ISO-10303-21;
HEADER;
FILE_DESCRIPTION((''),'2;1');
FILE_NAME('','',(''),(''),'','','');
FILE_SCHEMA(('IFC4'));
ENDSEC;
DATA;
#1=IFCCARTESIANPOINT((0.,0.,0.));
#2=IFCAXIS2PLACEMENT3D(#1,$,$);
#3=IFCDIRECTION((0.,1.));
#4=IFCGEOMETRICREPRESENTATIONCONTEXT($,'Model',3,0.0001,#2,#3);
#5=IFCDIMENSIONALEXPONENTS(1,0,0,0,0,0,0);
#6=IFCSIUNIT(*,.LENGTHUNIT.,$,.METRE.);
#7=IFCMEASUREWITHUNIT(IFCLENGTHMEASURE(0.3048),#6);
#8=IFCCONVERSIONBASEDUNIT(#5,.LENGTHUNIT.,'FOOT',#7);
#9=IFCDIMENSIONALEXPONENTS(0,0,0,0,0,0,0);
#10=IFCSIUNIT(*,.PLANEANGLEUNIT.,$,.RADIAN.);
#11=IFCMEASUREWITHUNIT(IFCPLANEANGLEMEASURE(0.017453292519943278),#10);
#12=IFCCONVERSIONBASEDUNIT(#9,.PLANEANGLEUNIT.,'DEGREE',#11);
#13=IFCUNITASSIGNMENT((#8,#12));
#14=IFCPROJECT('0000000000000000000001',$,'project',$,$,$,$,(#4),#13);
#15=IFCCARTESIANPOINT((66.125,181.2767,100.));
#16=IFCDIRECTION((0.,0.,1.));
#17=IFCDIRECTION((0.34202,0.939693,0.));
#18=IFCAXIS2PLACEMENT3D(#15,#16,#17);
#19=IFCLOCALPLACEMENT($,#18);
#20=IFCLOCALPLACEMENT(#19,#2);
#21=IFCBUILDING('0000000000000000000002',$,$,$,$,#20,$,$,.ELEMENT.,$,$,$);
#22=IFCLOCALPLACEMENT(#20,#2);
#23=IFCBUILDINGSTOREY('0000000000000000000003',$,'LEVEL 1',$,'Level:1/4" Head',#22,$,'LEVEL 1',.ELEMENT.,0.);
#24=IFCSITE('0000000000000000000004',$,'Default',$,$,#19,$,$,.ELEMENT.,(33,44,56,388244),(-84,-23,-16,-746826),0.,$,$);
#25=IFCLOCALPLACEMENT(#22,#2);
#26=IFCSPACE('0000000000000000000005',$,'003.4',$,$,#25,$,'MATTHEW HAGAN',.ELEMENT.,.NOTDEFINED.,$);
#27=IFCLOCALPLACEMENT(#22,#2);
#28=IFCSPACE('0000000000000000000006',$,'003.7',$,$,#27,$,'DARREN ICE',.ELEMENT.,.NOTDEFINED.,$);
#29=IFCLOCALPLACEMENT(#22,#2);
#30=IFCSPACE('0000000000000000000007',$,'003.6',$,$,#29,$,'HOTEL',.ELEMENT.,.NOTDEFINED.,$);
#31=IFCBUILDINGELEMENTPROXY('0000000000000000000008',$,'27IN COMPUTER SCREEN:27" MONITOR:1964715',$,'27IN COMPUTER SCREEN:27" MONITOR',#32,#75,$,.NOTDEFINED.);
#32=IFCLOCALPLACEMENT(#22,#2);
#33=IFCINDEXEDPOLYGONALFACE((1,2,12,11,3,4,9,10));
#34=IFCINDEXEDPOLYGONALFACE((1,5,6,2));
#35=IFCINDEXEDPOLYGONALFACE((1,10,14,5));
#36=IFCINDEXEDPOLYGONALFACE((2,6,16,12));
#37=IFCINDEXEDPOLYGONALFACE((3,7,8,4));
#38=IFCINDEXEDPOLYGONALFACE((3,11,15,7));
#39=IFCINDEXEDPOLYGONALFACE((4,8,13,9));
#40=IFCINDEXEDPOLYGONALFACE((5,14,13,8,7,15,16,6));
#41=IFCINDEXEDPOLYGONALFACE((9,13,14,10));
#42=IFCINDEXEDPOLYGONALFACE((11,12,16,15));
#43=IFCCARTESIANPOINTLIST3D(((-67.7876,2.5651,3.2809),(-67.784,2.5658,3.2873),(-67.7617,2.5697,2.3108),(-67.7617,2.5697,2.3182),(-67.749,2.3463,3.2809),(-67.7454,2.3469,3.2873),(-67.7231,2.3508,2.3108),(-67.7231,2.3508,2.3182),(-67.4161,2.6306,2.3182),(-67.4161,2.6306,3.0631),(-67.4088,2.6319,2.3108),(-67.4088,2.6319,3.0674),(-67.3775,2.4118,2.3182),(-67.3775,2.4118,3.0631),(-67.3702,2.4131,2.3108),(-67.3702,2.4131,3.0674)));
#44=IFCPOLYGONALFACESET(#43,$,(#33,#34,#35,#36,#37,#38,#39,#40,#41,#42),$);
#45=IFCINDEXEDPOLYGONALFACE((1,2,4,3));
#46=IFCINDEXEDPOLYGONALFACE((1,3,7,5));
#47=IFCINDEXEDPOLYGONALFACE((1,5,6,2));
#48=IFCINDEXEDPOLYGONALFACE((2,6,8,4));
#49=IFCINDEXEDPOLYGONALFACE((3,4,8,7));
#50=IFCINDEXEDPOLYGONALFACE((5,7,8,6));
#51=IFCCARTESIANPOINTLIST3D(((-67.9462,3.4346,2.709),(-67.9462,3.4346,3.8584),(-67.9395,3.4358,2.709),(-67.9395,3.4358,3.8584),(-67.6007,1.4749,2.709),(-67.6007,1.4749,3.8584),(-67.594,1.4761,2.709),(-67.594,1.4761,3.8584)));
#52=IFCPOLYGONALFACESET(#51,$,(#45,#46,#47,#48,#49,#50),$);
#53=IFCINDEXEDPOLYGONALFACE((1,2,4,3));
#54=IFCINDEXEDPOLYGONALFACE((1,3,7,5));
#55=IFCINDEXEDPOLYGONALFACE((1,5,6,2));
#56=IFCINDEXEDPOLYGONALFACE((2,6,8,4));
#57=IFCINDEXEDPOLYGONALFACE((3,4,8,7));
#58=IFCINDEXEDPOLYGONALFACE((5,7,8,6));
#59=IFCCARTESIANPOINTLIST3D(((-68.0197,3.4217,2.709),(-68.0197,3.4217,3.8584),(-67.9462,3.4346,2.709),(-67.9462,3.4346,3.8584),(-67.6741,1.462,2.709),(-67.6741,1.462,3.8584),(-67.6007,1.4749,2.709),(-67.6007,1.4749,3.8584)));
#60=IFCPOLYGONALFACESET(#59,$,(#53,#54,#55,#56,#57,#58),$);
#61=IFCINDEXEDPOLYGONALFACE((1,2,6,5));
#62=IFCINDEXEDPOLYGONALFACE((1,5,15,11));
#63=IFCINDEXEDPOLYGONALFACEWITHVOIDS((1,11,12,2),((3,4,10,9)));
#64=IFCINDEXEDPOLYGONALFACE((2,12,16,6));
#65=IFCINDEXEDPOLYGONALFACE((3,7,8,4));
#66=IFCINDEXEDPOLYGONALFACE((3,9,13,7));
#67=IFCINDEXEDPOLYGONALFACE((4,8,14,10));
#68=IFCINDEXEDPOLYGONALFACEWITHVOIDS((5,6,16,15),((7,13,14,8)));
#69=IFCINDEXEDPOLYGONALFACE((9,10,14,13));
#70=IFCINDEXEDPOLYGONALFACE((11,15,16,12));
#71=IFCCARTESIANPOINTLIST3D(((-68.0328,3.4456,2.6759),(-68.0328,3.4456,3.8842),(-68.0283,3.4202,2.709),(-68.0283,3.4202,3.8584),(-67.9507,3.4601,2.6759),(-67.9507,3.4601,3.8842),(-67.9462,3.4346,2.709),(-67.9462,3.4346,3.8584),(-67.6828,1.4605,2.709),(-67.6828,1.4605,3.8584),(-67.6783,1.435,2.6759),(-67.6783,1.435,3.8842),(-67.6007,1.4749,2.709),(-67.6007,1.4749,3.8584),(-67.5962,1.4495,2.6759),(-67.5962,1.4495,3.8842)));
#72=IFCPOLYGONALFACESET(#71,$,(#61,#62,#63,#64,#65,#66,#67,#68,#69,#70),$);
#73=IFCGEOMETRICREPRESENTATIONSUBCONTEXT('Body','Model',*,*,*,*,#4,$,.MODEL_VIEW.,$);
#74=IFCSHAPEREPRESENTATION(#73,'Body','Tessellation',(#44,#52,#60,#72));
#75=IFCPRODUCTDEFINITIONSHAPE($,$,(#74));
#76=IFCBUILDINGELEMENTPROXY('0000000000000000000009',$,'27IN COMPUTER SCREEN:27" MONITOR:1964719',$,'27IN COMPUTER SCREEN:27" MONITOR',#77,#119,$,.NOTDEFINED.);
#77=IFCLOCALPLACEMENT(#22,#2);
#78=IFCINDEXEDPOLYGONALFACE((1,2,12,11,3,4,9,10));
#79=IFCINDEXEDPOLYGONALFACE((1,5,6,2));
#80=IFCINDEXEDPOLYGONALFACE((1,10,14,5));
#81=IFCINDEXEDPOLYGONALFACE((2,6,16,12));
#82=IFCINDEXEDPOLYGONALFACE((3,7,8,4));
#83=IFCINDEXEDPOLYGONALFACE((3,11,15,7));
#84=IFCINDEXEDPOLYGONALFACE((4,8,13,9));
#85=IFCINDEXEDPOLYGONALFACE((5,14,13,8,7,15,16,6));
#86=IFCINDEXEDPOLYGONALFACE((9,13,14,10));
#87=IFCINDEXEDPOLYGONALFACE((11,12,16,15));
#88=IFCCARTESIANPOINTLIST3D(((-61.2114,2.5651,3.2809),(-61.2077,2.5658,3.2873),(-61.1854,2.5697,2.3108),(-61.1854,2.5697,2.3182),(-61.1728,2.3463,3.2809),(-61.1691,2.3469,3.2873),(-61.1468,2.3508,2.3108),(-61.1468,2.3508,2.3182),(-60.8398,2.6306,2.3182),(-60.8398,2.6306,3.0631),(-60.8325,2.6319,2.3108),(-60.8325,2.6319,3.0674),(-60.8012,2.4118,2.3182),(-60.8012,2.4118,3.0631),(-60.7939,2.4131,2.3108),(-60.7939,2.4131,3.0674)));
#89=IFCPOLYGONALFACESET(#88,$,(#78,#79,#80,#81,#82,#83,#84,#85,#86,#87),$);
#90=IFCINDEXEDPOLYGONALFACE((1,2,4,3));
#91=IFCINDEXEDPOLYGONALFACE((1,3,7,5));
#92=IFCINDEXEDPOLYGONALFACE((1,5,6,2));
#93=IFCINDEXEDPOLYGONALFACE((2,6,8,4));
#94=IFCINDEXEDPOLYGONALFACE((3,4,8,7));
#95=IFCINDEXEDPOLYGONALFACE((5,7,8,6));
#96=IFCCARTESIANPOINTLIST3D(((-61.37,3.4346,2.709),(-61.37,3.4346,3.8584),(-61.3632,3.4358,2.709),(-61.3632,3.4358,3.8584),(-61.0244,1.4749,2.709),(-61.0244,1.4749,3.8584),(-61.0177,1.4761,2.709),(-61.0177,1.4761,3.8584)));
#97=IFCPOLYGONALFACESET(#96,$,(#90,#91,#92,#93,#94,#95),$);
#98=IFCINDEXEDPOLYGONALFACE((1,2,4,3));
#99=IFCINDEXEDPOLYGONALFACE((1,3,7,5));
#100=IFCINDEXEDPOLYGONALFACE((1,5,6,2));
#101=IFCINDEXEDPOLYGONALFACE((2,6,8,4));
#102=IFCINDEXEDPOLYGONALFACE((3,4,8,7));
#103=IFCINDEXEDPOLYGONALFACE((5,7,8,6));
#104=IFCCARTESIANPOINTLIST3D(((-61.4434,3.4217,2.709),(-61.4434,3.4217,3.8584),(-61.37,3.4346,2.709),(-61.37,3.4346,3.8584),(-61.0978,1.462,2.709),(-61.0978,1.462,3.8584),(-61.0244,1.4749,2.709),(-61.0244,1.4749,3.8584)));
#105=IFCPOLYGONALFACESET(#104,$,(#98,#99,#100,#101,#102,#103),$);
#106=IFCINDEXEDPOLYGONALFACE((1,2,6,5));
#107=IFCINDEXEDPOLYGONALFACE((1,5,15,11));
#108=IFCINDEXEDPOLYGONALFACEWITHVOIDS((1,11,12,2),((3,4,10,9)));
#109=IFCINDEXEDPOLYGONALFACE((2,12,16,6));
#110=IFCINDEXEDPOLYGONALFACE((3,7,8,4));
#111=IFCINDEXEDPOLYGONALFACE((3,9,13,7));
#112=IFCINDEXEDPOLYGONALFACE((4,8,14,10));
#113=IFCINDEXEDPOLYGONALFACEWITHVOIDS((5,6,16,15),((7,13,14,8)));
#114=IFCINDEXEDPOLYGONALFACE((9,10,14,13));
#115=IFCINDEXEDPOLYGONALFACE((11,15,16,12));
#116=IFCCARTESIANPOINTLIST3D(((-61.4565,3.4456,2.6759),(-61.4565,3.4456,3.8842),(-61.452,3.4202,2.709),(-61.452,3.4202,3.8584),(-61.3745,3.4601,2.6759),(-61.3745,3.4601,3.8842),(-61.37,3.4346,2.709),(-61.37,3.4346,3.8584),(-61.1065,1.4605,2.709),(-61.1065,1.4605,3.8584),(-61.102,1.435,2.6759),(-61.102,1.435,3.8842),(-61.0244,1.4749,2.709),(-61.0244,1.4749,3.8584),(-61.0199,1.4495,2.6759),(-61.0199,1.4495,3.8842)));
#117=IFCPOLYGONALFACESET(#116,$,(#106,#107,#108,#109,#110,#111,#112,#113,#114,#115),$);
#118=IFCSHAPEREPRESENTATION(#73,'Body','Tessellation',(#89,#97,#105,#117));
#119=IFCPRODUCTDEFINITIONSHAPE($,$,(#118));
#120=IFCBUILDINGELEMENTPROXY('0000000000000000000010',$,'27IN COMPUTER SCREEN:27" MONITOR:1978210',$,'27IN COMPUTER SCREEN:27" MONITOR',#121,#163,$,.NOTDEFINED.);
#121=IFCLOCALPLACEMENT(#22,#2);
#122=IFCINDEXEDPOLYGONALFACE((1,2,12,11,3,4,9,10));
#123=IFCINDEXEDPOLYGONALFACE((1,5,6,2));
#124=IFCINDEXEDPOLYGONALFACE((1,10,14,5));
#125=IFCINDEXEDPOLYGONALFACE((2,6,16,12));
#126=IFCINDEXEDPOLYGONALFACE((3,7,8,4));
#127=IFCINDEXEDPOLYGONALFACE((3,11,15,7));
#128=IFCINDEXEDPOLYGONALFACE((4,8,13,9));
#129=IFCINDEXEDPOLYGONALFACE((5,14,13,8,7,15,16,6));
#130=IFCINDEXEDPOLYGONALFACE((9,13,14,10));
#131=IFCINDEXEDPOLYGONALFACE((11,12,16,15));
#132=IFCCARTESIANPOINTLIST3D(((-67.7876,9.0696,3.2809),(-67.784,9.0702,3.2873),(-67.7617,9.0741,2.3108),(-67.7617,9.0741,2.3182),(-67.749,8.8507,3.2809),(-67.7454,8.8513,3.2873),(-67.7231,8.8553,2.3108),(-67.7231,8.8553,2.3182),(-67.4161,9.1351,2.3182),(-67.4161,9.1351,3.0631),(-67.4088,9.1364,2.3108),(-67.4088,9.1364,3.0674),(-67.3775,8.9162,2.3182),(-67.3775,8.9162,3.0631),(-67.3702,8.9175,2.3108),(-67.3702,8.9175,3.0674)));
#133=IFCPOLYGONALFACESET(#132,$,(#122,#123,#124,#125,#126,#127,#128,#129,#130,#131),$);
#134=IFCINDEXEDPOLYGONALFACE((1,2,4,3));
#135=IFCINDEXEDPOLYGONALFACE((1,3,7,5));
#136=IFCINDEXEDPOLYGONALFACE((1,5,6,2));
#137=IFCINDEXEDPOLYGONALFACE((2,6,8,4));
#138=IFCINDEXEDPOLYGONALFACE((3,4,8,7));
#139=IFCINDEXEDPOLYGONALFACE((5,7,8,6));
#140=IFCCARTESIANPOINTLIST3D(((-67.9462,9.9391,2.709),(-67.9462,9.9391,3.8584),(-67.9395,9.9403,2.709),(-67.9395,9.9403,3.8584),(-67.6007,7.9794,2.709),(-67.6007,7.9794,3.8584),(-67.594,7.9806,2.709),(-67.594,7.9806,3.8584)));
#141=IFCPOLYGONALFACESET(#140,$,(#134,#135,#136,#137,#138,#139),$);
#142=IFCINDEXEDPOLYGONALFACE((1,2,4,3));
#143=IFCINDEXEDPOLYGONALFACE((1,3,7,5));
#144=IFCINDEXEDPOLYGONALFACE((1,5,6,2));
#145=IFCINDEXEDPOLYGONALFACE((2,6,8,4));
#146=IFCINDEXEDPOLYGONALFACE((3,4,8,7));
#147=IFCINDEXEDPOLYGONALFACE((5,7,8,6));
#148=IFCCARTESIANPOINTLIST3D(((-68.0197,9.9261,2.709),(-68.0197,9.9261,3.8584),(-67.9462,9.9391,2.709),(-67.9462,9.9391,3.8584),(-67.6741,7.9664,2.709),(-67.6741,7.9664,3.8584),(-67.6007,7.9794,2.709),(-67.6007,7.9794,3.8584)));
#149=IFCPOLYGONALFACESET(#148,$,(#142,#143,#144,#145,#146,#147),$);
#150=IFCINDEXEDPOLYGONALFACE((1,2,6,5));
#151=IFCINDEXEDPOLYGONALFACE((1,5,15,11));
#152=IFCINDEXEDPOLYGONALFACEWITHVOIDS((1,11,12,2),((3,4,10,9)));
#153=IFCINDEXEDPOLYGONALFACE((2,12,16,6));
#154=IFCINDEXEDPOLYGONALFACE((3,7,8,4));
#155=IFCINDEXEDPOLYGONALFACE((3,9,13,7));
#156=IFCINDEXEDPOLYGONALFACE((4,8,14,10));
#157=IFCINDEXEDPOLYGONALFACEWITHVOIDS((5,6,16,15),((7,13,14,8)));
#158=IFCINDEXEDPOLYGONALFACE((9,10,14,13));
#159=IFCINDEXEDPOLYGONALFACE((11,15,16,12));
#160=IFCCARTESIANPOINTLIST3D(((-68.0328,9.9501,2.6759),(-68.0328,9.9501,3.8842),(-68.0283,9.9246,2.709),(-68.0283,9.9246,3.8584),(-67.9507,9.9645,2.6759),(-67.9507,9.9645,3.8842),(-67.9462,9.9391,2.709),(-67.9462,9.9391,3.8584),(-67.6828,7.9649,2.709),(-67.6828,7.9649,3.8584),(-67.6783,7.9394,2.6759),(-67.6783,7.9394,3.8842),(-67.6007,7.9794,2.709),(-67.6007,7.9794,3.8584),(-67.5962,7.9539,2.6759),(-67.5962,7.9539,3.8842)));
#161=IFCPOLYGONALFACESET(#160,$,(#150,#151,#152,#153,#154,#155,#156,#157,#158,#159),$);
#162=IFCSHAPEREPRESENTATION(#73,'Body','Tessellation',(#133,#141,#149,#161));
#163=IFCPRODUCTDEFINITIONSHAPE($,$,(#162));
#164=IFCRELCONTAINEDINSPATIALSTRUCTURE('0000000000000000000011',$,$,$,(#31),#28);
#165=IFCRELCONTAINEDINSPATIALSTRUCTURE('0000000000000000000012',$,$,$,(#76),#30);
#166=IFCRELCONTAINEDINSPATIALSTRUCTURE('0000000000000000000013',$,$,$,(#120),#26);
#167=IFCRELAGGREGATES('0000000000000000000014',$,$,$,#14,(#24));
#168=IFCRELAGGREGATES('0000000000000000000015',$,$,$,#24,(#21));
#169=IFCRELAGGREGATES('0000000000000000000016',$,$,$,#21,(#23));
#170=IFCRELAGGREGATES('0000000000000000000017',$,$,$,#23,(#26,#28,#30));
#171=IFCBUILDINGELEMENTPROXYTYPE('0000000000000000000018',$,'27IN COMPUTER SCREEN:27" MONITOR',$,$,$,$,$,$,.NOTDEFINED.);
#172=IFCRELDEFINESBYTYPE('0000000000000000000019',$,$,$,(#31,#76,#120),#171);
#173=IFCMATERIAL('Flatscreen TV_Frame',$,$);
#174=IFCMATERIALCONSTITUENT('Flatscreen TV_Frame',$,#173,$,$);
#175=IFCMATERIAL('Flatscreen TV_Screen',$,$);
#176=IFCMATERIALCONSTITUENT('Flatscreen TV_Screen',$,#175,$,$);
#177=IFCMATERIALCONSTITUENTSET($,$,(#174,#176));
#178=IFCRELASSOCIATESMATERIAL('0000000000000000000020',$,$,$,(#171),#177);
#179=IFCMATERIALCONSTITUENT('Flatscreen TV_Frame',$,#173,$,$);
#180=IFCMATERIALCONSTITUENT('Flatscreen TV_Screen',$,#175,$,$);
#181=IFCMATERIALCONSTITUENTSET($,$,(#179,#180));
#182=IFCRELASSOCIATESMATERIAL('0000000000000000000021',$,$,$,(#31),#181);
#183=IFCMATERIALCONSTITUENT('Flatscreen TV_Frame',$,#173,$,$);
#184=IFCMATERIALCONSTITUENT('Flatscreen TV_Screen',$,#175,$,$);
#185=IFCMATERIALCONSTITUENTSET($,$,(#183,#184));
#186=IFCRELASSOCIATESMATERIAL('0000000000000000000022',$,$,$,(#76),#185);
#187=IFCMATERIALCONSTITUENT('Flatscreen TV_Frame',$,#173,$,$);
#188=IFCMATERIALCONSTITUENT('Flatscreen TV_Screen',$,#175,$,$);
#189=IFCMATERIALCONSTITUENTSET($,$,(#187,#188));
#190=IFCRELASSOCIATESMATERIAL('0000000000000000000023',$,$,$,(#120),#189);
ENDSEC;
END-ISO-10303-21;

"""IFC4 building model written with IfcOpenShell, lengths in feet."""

from ifc_helpers import new_model, entity, si_unit, converted_unit, direction, frame, frame_2d, origin, origin_2d_with_axis, place, context, subcontext, project, spatial, polyline, rectangle, outline, extrude, source, transform, mapped, material, constituent, constituent_set, type_object, type_shapes, element, save


model = new_model("IFC4")

# Units and contexts
model_context = context("Model", 3, precision=0.0001, world=origin(), true_north=direction((0.0, 1.0)))
body_context = subcontext(model_context, "Body", "Model", "MODEL_VIEW")
ifc_project = project(units=[converted_unit("LENGTHUNIT", "FOOT", entity("IfcLengthMeasure", 0.3048), si_unit("LENGTHUNIT", "METRE"), dimensions=[1, 0, 0, 0, 0, 0, 0]), converted_unit("PLANEANGLEUNIT", "DEGREE", entity("IfcPlaneAngleMeasure", 0.017453292519943278), si_unit("PLANEANGLEUNIT", "RADIAN"), dimensions=[0, 0, 0, 0, 0, 0, 0])], contexts=[model_context])

# Site, building, storey
site_placement = place(None, frame((66.125, 181.2767, 100.0), z_axis=(0.0, 0.0, 1.0), x_axis=(0.34202, 0.939693, 0.0)))
site = spatial("IfcSite", under=ifc_project, at=site_placement, Name="Default", CompositionType="ELEMENT", RefLatitude=(33, 44, 56, 388244), RefLongitude=(-84, -23, -16, -746826), RefElevation=0.0)
building_placement = place(site_placement, origin())
building = spatial("IfcBuilding", under=site, at=building_placement, CompositionType="ELEMENT")
storey_placement = place(building_placement, origin())
storey = spatial("IfcBuildingStorey", under=building, at=storey_placement, Name="LEVEL 1", ObjectType="Level:1/4\" Head", LongName="LEVEL 1", CompositionType="ELEMENT", Elevation=0.0)

# Shared definitions
space_1_placement = place(storey_placement, origin())
space_1 = spatial("IfcSpace", under=storey, at=space_1_placement, Name="003.4", LongName="MATTHEW HAGAN", CompositionType="ELEMENT", PredefinedType="NOTDEFINED")

# Shared definitions
space_2_placement = place(storey_placement, origin())
space_2 = spatial("IfcSpace", under=storey, at=space_2_placement, Name="003.7", LongName="DARREN ICE", CompositionType="ELEMENT", PredefinedType="NOTDEFINED")

# Shared definitions
space_3_placement = place(storey_placement, origin())
space_3 = spatial("IfcSpace", under=storey, at=space_3_placement, Name="003.6", LongName="HOTEL", CompositionType="ELEMENT", PredefinedType="NOTDEFINED")

# Shared definitions
ifc_material_1 = material(Name="Flatscreen TV_Frame")
ifc_material_2 = material(Name="Flatscreen TV_Screen")

# Building element proxies
ifc_constituent_1 = constituent(ifc_material_1, Name="Flatscreen TV_Frame")
ifc_constituent_2 = constituent(ifc_material_2, Name="Flatscreen TV_Screen")
ifc_constituent_set_1 = constituent_set(constituents=[ifc_constituent_1, ifc_constituent_2])
ifc_constituent_3 = constituent(ifc_material_1, Name="Flatscreen TV_Frame")
ifc_constituent_4 = constituent(ifc_material_2, Name="Flatscreen TV_Screen")
ifc_constituent_set_2 = constituent_set(constituents=[ifc_constituent_3, ifc_constituent_4])
building_element_proxy_type_1 = type_object("IfcBuildingElementProxyType", Name="27IN COMPUTER SCREEN:27\" MONITOR", PredefinedType="NOTDEFINED", material=ifc_constituent_set_2)
shared_shape_1 = source(origin(), body_context, "Body", "SweptSolid", [
    extrude(outline(polyline([(0.3657, -0.4392), (0.3731, -0.4392), (0.3731, 0.0007), (-0.2821, 0.379), (-0.4613, 0.0686), (-0.4548, 0.0649), (-0.2794, 0.3688), (0.3657, -0.0036), (0.3657, -0.4392)])), frame((-0.1111, 0.0264, 0.0687), z_axis=(1.0, 0.0, 0.0), x_axis=(0.0, -0.5, 0.866025)), (0.0, 0.0, 1.0), 0.2222),
    extrude(rectangle(XDim=1.9899, YDim=0.0068, at=origin_2d_with_axis()), frame((0.0, 0.2257, 0.0331), z_axis=(0.0, 0.0, 1.0), x_axis=(-1.0, 0.0, 0.0)), (0.0, 0.0, 1.0), 1.1493),
    extrude(rectangle(XDim=1.9899, YDim=0.0746, at=frame_2d((0.0, 0.0), x_axis=(1.0, 0.0))), frame((0.0, 0.2664, 0.0331), z_axis=(0.0, 0.0, 1.0), x_axis=(-1.0, 0.0, 0.0)), (0.0, 0.0, 1.0), 1.1493),
    extrude(outline(polyline([(-0.6042, -1.0208), (0.6042, -1.0208), (0.6042, 1.0208), (-0.6042, 1.0208), (-0.6042, -1.0208)]), holes=[polyline([(-0.5783, -0.995), (-0.5783, 0.995), (0.571, 0.995), (0.571, -0.995), (-0.5783, -0.995)])]), frame((0.0, 0.2292, 0.6042), z_axis=(0.0, 1.0, 0.0), x_axis=(0.0, 0.0, -1.0)), (0.0, 0.0, 1.0), 0.0833),
])
type_shapes(building_element_proxy_type_1, [shared_shape_1])
proxy_1_placement = place(space_2_placement, frame((-67.5478, 2.4946, 2.6759), z_axis=(0.0, 0.0, 1.0), x_axis=(-0.173648, 0.984808, 0.0)))
element("IfcBuildingElementProxy", 1, at=proxy_1_placement, inside=space_2, type_object=building_element_proxy_type_1, material=ifc_constituent_set_1, Name="27IN COMPUTER SCREEN:27\" MONITOR:1964715", ObjectType="27IN COMPUTER SCREEN:27\" MONITOR", PredefinedType="NOTDEFINED", context=body_context, shape_type="MappedRepresentation", body=[
    mapped(shared_shape_1, transform((0.0, 0.0, 0.0), scale=1.0)),
])
ifc_constituent_5 = constituent(ifc_material_1, Name="Flatscreen TV_Frame")
ifc_constituent_6 = constituent(ifc_material_2, Name="Flatscreen TV_Screen")
ifc_constituent_set_3 = constituent_set(constituents=[ifc_constituent_5, ifc_constituent_6])
proxy_2_placement = place(space_3_placement, frame((-60.9715, 2.4946, 2.6759), z_axis=(0.0, 0.0, 1.0), x_axis=(-0.173648, 0.984808, 0.0)))
element("IfcBuildingElementProxy", 2, at=proxy_2_placement, inside=space_3, type_object=building_element_proxy_type_1, material=ifc_constituent_set_3, Name="27IN COMPUTER SCREEN:27\" MONITOR:1964719", ObjectType="27IN COMPUTER SCREEN:27\" MONITOR", PredefinedType="NOTDEFINED", context=body_context, shape_type="MappedRepresentation", body=[
    mapped(shared_shape_1, transform((0.0, 0.0, 0.0), scale=1.0)),
])
ifc_constituent_7 = constituent(ifc_material_1, Name="Flatscreen TV_Frame")
ifc_constituent_8 = constituent(ifc_material_2, Name="Flatscreen TV_Screen")
ifc_constituent_set_4 = constituent_set(constituents=[ifc_constituent_7, ifc_constituent_8])
proxy_3_placement = place(space_1_placement, frame((-67.5478, 8.999, 2.6759), z_axis=(0.0, 0.0, 1.0), x_axis=(-0.173648, 0.984808, 0.0)))
element("IfcBuildingElementProxy", 3, at=proxy_3_placement, inside=space_1, type_object=building_element_proxy_type_1, material=ifc_constituent_set_4, Name="27IN COMPUTER SCREEN:27\" MONITOR:1978210", ObjectType="27IN COMPUTER SCREEN:27\" MONITOR", PredefinedType="NOTDEFINED", context=body_context, shape_type="MappedRepresentation", body=[
    mapped(shared_shape_1, transform((0.0, 0.0, 0.0), scale=1.0)),
])

save(model, "model.ifc")
